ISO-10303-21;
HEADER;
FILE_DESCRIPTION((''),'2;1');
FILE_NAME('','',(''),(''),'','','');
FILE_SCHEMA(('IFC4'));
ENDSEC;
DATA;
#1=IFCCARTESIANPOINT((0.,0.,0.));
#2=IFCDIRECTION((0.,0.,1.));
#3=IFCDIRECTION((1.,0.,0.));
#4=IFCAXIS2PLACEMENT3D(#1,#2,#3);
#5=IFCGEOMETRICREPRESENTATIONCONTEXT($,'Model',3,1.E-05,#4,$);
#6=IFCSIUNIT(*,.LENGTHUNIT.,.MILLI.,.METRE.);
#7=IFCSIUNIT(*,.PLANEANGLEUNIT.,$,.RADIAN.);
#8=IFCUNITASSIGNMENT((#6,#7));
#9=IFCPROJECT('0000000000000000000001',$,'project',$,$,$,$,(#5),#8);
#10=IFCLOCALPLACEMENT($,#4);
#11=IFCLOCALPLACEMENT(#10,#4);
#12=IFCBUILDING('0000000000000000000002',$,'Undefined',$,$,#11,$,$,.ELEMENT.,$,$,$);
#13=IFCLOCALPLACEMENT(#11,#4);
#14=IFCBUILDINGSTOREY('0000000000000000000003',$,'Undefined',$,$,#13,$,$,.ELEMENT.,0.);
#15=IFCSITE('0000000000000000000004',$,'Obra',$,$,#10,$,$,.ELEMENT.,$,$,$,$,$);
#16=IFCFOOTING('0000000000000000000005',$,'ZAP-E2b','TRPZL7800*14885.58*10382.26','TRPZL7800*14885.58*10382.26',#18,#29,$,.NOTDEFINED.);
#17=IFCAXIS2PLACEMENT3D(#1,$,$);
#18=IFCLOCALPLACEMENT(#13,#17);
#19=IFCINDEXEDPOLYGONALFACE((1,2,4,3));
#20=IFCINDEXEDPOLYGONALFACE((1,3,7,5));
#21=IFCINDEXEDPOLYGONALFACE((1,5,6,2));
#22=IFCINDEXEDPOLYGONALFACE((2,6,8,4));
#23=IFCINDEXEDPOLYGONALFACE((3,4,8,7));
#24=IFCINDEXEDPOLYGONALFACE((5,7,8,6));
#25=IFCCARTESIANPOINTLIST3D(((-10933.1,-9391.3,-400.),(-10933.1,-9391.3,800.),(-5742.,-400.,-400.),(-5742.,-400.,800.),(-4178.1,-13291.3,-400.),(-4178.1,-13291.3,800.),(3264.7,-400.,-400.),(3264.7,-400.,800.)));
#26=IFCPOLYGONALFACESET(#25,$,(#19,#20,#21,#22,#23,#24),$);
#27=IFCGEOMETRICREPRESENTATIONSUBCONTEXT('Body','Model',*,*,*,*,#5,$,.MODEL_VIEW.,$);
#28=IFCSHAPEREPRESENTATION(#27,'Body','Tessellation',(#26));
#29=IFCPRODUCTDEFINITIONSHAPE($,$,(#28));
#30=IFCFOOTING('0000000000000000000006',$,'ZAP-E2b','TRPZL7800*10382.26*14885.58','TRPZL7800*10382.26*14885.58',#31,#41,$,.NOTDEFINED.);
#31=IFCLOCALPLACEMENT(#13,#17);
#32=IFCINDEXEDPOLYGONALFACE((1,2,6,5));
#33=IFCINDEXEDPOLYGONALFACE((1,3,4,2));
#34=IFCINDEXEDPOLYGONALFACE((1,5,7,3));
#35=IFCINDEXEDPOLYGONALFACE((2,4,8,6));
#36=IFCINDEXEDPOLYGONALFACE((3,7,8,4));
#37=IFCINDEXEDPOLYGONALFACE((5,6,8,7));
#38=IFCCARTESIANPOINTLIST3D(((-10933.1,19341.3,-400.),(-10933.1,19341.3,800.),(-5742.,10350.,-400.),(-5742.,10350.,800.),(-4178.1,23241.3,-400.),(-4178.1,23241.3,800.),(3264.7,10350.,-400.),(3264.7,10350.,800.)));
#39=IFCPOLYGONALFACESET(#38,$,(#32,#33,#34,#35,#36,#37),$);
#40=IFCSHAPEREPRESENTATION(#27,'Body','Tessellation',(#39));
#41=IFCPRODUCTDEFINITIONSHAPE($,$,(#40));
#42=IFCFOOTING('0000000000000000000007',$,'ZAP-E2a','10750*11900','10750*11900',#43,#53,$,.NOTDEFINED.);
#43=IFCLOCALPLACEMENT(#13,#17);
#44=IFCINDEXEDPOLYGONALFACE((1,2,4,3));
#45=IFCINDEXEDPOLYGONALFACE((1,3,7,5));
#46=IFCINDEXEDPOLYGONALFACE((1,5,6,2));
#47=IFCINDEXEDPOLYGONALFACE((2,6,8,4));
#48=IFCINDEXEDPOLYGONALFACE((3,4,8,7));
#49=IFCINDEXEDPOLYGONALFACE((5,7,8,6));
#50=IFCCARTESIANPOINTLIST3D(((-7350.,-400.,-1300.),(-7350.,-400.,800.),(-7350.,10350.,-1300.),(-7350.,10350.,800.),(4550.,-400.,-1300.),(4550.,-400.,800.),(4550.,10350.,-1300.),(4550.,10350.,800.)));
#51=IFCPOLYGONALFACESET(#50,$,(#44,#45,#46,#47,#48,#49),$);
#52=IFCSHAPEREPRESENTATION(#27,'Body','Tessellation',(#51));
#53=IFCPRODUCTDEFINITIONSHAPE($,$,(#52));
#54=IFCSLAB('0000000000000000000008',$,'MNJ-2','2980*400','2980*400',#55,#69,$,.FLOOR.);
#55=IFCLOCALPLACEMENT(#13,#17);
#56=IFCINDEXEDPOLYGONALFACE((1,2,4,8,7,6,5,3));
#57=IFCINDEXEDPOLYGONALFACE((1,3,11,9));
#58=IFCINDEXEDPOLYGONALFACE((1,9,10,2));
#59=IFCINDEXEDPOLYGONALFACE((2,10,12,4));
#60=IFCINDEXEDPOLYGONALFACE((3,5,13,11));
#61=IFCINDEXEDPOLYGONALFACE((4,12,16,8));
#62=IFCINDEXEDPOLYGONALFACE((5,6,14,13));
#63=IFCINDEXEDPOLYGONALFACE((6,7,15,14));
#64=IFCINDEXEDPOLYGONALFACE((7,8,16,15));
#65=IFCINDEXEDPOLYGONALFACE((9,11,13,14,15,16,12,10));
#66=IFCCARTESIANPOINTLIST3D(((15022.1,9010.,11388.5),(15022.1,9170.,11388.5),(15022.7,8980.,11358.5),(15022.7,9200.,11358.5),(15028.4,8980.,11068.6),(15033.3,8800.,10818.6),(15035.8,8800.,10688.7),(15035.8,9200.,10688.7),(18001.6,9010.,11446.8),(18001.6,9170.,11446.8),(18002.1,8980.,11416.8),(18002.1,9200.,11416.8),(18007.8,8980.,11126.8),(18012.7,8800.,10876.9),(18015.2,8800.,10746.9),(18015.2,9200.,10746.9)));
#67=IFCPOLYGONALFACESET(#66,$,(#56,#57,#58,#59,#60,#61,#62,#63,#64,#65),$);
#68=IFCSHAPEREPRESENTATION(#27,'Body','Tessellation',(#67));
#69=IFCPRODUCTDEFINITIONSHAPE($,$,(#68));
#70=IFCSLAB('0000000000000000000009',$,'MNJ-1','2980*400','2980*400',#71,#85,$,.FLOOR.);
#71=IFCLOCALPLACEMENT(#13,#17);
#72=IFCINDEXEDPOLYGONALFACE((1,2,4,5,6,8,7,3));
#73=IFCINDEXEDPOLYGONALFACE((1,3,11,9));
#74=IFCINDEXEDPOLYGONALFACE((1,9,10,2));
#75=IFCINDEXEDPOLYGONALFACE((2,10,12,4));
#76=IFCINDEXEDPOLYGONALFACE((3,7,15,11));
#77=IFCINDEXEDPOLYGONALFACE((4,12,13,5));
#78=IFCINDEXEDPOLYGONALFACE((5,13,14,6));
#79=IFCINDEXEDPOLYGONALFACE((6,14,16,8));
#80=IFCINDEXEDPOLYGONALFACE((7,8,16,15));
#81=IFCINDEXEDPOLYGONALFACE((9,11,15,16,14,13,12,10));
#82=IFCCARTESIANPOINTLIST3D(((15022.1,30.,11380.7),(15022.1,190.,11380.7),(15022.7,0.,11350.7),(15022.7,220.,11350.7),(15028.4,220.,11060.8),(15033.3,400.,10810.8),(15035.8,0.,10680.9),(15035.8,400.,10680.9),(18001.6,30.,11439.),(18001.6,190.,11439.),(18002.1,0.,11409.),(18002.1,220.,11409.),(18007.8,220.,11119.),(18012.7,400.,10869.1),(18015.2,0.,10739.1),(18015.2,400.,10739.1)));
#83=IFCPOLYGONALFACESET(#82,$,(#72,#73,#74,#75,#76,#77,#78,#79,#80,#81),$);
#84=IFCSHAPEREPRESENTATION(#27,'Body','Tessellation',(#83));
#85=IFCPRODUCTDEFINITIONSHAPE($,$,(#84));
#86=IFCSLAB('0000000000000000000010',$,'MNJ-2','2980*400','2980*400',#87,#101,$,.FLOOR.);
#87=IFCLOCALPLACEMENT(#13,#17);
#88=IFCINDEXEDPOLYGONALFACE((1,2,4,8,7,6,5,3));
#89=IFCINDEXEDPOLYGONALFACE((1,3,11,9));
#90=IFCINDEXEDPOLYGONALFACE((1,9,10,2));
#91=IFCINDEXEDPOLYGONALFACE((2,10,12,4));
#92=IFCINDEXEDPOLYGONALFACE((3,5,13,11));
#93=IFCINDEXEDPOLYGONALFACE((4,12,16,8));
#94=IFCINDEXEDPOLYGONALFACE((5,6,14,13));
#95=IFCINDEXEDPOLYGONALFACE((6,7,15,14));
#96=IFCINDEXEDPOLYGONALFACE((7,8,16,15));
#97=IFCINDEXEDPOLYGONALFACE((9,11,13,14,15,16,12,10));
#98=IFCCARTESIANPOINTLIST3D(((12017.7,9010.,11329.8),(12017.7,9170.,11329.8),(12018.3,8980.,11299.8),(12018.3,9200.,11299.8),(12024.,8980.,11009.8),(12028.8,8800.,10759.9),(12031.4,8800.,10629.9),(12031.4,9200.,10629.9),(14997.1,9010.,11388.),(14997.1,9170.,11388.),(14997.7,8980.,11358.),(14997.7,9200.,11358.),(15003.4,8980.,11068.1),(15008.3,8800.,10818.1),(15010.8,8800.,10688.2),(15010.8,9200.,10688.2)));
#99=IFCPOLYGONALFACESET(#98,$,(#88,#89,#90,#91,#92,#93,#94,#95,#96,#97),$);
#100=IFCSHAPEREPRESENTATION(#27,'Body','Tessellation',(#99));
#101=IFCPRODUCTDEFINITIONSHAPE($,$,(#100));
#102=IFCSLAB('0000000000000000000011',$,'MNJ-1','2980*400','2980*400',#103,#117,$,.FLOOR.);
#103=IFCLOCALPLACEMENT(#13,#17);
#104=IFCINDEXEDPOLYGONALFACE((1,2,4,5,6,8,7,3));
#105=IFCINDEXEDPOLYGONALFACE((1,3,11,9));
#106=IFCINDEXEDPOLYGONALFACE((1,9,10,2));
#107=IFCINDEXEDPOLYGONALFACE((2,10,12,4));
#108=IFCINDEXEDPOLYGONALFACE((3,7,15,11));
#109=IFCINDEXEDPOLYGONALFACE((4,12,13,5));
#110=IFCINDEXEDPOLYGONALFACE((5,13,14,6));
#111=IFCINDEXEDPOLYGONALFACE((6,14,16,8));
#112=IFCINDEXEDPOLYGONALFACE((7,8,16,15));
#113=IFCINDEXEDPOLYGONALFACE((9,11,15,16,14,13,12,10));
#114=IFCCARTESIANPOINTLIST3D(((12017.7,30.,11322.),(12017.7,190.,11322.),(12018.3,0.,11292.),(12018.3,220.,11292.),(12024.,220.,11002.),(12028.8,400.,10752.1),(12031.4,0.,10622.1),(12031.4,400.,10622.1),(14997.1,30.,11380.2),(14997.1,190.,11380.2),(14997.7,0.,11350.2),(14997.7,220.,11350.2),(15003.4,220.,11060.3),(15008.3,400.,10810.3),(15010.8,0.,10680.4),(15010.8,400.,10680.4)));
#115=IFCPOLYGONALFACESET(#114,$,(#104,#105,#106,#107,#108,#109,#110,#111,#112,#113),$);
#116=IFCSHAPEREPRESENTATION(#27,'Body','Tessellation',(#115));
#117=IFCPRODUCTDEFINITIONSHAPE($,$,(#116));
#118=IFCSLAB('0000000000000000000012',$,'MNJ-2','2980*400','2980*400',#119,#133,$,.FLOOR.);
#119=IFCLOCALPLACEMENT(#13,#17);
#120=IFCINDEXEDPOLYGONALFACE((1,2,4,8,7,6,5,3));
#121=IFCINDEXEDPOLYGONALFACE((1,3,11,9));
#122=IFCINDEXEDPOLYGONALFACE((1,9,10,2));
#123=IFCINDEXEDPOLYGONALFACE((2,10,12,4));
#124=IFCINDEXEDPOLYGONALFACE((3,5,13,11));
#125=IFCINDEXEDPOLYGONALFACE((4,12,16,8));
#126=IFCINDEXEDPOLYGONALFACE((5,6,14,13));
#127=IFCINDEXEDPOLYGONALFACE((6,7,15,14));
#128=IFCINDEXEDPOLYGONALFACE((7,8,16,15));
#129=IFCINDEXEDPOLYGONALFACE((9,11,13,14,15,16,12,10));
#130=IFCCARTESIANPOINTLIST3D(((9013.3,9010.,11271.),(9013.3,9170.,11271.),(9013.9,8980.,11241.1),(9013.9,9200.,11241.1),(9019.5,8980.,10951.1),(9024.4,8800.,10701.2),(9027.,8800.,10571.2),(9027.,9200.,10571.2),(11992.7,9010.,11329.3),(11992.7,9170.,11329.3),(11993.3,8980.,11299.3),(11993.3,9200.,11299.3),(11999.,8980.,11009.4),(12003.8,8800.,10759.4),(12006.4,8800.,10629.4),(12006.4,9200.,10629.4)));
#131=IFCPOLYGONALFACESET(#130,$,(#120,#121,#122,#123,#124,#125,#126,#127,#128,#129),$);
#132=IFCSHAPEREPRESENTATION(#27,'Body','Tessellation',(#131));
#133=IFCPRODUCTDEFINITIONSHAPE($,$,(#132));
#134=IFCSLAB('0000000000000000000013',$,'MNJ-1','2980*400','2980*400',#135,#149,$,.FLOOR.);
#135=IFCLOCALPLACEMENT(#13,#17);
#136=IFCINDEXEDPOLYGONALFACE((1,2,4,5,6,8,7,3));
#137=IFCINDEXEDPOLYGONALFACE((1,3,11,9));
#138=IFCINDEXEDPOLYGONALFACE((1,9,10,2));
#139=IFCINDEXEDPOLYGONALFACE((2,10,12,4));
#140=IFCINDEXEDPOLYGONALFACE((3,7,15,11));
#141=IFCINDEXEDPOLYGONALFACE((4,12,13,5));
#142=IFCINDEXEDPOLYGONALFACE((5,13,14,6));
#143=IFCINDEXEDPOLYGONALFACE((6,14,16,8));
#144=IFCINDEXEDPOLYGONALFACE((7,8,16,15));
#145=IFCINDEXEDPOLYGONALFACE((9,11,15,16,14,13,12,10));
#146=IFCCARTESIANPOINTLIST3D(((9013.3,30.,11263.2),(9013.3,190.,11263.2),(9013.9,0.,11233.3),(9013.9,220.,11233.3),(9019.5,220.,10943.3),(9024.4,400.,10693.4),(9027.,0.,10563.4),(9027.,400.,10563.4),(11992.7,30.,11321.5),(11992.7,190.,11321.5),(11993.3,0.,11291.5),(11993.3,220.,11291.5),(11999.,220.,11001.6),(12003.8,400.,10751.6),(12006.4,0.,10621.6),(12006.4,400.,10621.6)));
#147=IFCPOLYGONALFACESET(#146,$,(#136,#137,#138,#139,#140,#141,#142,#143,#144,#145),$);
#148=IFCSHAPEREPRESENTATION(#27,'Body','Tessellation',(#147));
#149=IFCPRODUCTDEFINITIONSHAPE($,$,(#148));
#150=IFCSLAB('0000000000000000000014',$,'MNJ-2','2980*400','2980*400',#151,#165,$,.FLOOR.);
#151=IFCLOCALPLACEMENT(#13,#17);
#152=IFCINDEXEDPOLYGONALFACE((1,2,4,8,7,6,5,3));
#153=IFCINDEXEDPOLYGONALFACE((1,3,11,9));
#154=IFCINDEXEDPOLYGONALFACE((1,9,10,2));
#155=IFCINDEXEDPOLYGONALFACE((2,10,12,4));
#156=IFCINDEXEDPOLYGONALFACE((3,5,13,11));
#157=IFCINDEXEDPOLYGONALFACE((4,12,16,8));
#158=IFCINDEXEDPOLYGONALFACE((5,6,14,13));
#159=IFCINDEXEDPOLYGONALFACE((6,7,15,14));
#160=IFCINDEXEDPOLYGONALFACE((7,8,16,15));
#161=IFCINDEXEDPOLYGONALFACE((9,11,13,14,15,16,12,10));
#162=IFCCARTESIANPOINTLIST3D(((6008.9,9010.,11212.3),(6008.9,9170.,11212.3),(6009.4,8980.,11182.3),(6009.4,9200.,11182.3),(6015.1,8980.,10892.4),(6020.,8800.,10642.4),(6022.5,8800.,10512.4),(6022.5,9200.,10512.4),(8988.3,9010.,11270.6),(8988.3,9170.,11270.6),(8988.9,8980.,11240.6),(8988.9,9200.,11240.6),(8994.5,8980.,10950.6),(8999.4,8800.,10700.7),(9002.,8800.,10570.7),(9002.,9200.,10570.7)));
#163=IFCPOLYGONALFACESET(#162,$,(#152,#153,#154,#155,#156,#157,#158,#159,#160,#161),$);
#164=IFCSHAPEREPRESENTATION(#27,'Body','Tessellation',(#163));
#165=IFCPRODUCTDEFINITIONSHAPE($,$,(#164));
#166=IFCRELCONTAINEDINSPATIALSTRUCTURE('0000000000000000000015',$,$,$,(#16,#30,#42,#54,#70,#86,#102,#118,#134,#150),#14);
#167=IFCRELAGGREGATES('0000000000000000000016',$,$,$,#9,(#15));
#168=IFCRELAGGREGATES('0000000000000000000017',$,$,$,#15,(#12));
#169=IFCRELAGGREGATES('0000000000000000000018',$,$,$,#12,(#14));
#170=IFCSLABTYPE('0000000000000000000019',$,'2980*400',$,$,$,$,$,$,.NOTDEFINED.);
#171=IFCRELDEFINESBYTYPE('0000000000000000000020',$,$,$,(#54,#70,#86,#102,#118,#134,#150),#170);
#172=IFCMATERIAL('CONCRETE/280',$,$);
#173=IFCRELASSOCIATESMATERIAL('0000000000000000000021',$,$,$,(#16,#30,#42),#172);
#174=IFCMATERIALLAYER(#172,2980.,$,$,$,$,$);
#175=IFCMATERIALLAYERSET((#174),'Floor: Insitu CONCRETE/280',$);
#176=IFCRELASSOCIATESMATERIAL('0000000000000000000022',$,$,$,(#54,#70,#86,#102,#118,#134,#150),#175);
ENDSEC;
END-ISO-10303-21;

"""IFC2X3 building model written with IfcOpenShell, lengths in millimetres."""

from ifc_helpers import new_model, si_unit, frame, origin_with_axes, origin_2d_with_axis, place, context, subcontext, project, spatial, polyline, rectangle, outline, extrude, material, layer, layer_set, layer_usage, type_object, element, save


model = new_model("IFC2X3")

# Units and contexts
model_context = context("Model", 3, precision=1e-05, world=origin_with_axes())
body_context = subcontext(model_context, "Body", "Model", "MODEL_VIEW")
ifc_project = project(units=[si_unit("LENGTHUNIT", "METRE", prefix="MILLI"), si_unit("PLANEANGLEUNIT", "RADIAN")], contexts=[model_context])

# Site, building, storey
site_placement = place(None, origin_with_axes())
site = spatial("IfcSite", under=ifc_project, at=site_placement, Name="Obra", CompositionType="ELEMENT")
building_placement = place(site_placement, origin_with_axes())
building = spatial("IfcBuilding", under=site, at=building_placement, Name="Undefined", CompositionType="ELEMENT")
storey_placement = place(building_placement, origin_with_axes())
storey = spatial("IfcBuildingStorey", under=building, at=storey_placement, Name="Undefined", CompositionType="ELEMENT", Elevation=0.0)

# Footings
ifc_material_1 = material(Name="CONCRETE/280")
footing_1_placement = place(storey_placement, frame((-3834.2, -4895.6, -400.0), z_axis=(0.866025, -0.5, 0.0), x_axis=(0.0, 0.0, 1.0)))
element("IfcFooting", 1, at=footing_1_placement, inside=storey, material=ifc_material_1, Name="ZAP-E2b", Description="TRPZL7800*14885.58*10382.26", ObjectType="TRPZL7800*14885.58*10382.26", PredefinedType="NOTDEFINED", context=body_context, shape_type="SweptSolid", body=[
    extrude(outline(polyline([(-7442.8, -3900.0), (-7442.8, 3900.0), (7442.8, 3900.0), (2939.5, -3900.0), (-7442.8, -3900.0)])), frame((1200.0, 0.0, 0.0), z_axis=(-1.0, 0.0, 0.0), x_axis=(0.0, -1.0, 0.0)), (0.0, 0.0, 1.0), 1200.0),
])
footing_2_placement = place(storey_placement, frame((-4960.1, 16795.6, -400.0), z_axis=(-0.866025, -0.5, 0.0), x_axis=(0.0, 0.0, 1.0)))
element("IfcFooting", 2, at=footing_2_placement, inside=storey, material=ifc_material_1, Name="ZAP-E2b", Description="TRPZL7800*10382.26*14885.58", ObjectType="TRPZL7800*10382.26*14885.58", PredefinedType="NOTDEFINED", context=body_context, shape_type="SweptSolid", body=[
    extrude(outline(polyline([(-5191.1, 3900.0), (5191.1, 3900.0), (9694.4, -3900.0), (-5191.1, -3900.0), (-5191.1, 3900.0)])), frame((1200.0, 0.0, 0.0), z_axis=(-1.0, 0.0, 0.0), x_axis=(0.0, -1.0, 0.0)), (0.0, 0.0, 1.0), 1200.0),
])
footing_3_placement = place(storey_placement, frame((-1400.0, 4975.0, -1300.0), z_axis=(0.0, -1.0, 0.0), x_axis=(0.0, 0.0, 1.0)))
element("IfcFooting", 3, at=footing_3_placement, inside=storey, material=ifc_material_1, Name="ZAP-E2a", Description="10750*11900", ObjectType="10750*11900", PredefinedType="NOTDEFINED", context=body_context, shape_type="SweptSolid", body=[
    extrude(rectangle(XDim=11900.0, YDim=10750.0, at=origin_2d_with_axis()), frame((2100.0, 0.0, 0.0), z_axis=(-1.0, 0.0, 0.0), x_axis=(0.0, -1.0, 0.0)), (0.0, 0.0, 1.0), 2100.0),
])

# Slabs
ifc_layer_1 = layer(ifc_material_1, 2980.0)
ifc_layer_set_1 = layer_set([ifc_layer_1], Name="Floor: Insitu CONCRETE/280")
ifc_layer_usage_1 = layer_usage(ifc_layer_set_1, "AXIS3", "POSITIVE", -1490.0)
slab_type_1 = type_object("IfcSlabType", Name="2980*400", PredefinedType="NOTDEFINED")
slab_1_placement = place(storey_placement, frame((16512.4, 9200.0, 11387.7), z_axis=(-0.999809, 0.0, -0.019547), x_axis=(0.019547, 0.0, -0.999809)))
element("IfcSlab", 4, at=slab_1_placement, inside=storey, type_object=slab_type_1, material=ifc_layer_usage_1, Name="MNJ-2", Description="2980*400", ObjectType="2980*400", PredefinedType="FLOOR", context=body_context, shape_type="SweptSolid", body=[
    extrude(outline(polyline([(0.0, 0.0), (670.0, 0.0), (670.0, 400.0), (540.0, 400.0), (290.0, 220.0), (0.0, 220.0), (-30.0, 190.0), (-30.0, 30.0), (0.0, 0.0)])), frame((0.0, 0.0, -1490.0), z_axis=(0.0, 0.0, 1.0), x_axis=(1.0, 0.0, 0.0)), (0.0, 0.0, 1.0), 2980.0),
])
ifc_layer_usage_2 = layer_usage(ifc_layer_set_1, "AXIS3", "POSITIVE", -1490.0)
slab_2_placement = place(storey_placement, frame((16512.4, 0.0, 11379.9), z_axis=(0.999809, 0.0, 0.019547), x_axis=(0.019547, 0.0, -0.999809)))
element("IfcSlab", 5, at=slab_2_placement, inside=storey, type_object=slab_type_1, material=ifc_layer_usage_2, Name="MNJ-1", Description="2980*400", ObjectType="2980*400", PredefinedType="FLOOR", context=body_context, shape_type="SweptSolid", body=[
    extrude(outline(polyline([(0.0, 0.0), (670.0, 0.0), (670.0, 400.0), (540.0, 400.0), (290.0, 220.0), (0.0, 220.0), (-30.0, 190.0), (-30.0, 30.0), (0.0, 0.0)])), frame((0.0, 0.0, -1490.0), z_axis=(0.0, 0.0, 1.0), x_axis=(1.0, 0.0, 0.0)), (0.0, 0.0, 1.0), 2980.0),
])
ifc_layer_usage_3 = layer_usage(ifc_layer_set_1, "AXIS3", "POSITIVE", -1490.0)
slab_3_placement = place(storey_placement, frame((13508.0, 9200.0, 11328.9), z_axis=(-0.999809, 0.0, -0.019547), x_axis=(0.019547, 0.0, -0.999809)))
element("IfcSlab", 6, at=slab_3_placement, inside=storey, type_object=slab_type_1, material=ifc_layer_usage_3, Name="MNJ-2", Description="2980*400", ObjectType="2980*400", PredefinedType="FLOOR", context=body_context, shape_type="SweptSolid", body=[
    extrude(outline(polyline([(0.0, 0.0), (670.0, 0.0), (670.0, 400.0), (540.0, 400.0), (290.0, 220.0), (0.0, 220.0), (-30.0, 190.0), (-30.0, 30.0), (0.0, 0.0)])), frame((0.0, 0.0, -1490.0), z_axis=(0.0, 0.0, 1.0), x_axis=(1.0, 0.0, 0.0)), (0.0, 0.0, 1.0), 2980.0),
])
ifc_layer_usage_4 = layer_usage(ifc_layer_set_1, "AXIS3", "POSITIVE", -1490.0)
slab_4_placement = place(storey_placement, frame((13508.0, 0.0, 11321.1), z_axis=(0.999809, 0.0, 0.019547), x_axis=(0.019547, 0.0, -0.999809)))
element("IfcSlab", 7, at=slab_4_placement, inside=storey, type_object=slab_type_1, material=ifc_layer_usage_4, Name="MNJ-1", Description="2980*400", ObjectType="2980*400", PredefinedType="FLOOR", context=body_context, shape_type="SweptSolid", body=[
    extrude(outline(polyline([(0.0, 0.0), (670.0, 0.0), (670.0, 400.0), (540.0, 400.0), (290.0, 220.0), (0.0, 220.0), (-30.0, 190.0), (-30.0, 30.0), (0.0, 0.0)])), frame((0.0, 0.0, -1490.0), z_axis=(0.0, 0.0, 1.0), x_axis=(1.0, 0.0, 0.0)), (0.0, 0.0, 1.0), 2980.0),
])
ifc_layer_usage_5 = layer_usage(ifc_layer_set_1, "AXIS3", "POSITIVE", -1490.0)
slab_5_placement = place(storey_placement, frame((10503.6, 9200.0, 11270.2), z_axis=(-0.999809, 0.0, -0.019547), x_axis=(0.019547, 0.0, -0.999809)))
element("IfcSlab", 8, at=slab_5_placement, inside=storey, type_object=slab_type_1, material=ifc_layer_usage_5, Name="MNJ-2", Description="2980*400", ObjectType="2980*400", PredefinedType="FLOOR", context=body_context, shape_type="SweptSolid", body=[
    extrude(outline(polyline([(0.0, 0.0), (670.0, 0.0), (670.0, 400.0), (540.0, 400.0), (290.0, 220.0), (0.0, 220.0), (-30.0, 190.0), (-30.0, 30.0), (0.0, 0.0)])), frame((0.0, 0.0, -1490.0), z_axis=(0.0, 0.0, 1.0), x_axis=(1.0, 0.0, 0.0)), (0.0, 0.0, 1.0), 2980.0),
])
ifc_layer_usage_6 = layer_usage(ifc_layer_set_1, "AXIS3", "POSITIVE", -1490.0)
slab_6_placement = place(storey_placement, frame((10503.6, 0.0, 11262.4), z_axis=(0.999809, 0.0, 0.019547), x_axis=(0.019547, 0.0, -0.999809)))
element("IfcSlab", 9, at=slab_6_placement, inside=storey, type_object=slab_type_1, material=ifc_layer_usage_6, Name="MNJ-1", Description="2980*400", ObjectType="2980*400", PredefinedType="FLOOR", context=body_context, shape_type="SweptSolid", body=[
    extrude(outline(polyline([(0.0, 0.0), (670.0, 0.0), (670.0, 400.0), (540.0, 400.0), (290.0, 220.0), (0.0, 220.0), (-30.0, 190.0), (-30.0, 30.0), (0.0, 0.0)])), frame((0.0, 0.0, -1490.0), z_axis=(0.0, 0.0, 1.0), x_axis=(1.0, 0.0, 0.0)), (0.0, 0.0, 1.0), 2980.0),
])
ifc_layer_usage_7 = layer_usage(ifc_layer_set_1, "AXIS3", "POSITIVE", -1490.0)
slab_7_placement = place(storey_placement, frame((7499.2, 9200.0, 11211.4), z_axis=(-0.999809, 0.0, -0.019547), x_axis=(0.019547, 0.0, -0.999809)))
element("IfcSlab", 10, at=slab_7_placement, inside=storey, type_object=slab_type_1, material=ifc_layer_usage_7, Name="MNJ-2", Description="2980*400", ObjectType="2980*400", PredefinedType="FLOOR", context=body_context, shape_type="SweptSolid", body=[
    extrude(outline(polyline([(0.0, 0.0), (670.0, 0.0), (670.0, 400.0), (540.0, 400.0), (290.0, 220.0), (0.0, 220.0), (-30.0, 190.0), (-30.0, 30.0), (0.0, 0.0)])), frame((0.0, 0.0, -1490.0), z_axis=(0.0, 0.0, 1.0), x_axis=(1.0, 0.0, 0.0)), (0.0, 0.0, 1.0), 2980.0),
])

save(model, "model.ifc")
